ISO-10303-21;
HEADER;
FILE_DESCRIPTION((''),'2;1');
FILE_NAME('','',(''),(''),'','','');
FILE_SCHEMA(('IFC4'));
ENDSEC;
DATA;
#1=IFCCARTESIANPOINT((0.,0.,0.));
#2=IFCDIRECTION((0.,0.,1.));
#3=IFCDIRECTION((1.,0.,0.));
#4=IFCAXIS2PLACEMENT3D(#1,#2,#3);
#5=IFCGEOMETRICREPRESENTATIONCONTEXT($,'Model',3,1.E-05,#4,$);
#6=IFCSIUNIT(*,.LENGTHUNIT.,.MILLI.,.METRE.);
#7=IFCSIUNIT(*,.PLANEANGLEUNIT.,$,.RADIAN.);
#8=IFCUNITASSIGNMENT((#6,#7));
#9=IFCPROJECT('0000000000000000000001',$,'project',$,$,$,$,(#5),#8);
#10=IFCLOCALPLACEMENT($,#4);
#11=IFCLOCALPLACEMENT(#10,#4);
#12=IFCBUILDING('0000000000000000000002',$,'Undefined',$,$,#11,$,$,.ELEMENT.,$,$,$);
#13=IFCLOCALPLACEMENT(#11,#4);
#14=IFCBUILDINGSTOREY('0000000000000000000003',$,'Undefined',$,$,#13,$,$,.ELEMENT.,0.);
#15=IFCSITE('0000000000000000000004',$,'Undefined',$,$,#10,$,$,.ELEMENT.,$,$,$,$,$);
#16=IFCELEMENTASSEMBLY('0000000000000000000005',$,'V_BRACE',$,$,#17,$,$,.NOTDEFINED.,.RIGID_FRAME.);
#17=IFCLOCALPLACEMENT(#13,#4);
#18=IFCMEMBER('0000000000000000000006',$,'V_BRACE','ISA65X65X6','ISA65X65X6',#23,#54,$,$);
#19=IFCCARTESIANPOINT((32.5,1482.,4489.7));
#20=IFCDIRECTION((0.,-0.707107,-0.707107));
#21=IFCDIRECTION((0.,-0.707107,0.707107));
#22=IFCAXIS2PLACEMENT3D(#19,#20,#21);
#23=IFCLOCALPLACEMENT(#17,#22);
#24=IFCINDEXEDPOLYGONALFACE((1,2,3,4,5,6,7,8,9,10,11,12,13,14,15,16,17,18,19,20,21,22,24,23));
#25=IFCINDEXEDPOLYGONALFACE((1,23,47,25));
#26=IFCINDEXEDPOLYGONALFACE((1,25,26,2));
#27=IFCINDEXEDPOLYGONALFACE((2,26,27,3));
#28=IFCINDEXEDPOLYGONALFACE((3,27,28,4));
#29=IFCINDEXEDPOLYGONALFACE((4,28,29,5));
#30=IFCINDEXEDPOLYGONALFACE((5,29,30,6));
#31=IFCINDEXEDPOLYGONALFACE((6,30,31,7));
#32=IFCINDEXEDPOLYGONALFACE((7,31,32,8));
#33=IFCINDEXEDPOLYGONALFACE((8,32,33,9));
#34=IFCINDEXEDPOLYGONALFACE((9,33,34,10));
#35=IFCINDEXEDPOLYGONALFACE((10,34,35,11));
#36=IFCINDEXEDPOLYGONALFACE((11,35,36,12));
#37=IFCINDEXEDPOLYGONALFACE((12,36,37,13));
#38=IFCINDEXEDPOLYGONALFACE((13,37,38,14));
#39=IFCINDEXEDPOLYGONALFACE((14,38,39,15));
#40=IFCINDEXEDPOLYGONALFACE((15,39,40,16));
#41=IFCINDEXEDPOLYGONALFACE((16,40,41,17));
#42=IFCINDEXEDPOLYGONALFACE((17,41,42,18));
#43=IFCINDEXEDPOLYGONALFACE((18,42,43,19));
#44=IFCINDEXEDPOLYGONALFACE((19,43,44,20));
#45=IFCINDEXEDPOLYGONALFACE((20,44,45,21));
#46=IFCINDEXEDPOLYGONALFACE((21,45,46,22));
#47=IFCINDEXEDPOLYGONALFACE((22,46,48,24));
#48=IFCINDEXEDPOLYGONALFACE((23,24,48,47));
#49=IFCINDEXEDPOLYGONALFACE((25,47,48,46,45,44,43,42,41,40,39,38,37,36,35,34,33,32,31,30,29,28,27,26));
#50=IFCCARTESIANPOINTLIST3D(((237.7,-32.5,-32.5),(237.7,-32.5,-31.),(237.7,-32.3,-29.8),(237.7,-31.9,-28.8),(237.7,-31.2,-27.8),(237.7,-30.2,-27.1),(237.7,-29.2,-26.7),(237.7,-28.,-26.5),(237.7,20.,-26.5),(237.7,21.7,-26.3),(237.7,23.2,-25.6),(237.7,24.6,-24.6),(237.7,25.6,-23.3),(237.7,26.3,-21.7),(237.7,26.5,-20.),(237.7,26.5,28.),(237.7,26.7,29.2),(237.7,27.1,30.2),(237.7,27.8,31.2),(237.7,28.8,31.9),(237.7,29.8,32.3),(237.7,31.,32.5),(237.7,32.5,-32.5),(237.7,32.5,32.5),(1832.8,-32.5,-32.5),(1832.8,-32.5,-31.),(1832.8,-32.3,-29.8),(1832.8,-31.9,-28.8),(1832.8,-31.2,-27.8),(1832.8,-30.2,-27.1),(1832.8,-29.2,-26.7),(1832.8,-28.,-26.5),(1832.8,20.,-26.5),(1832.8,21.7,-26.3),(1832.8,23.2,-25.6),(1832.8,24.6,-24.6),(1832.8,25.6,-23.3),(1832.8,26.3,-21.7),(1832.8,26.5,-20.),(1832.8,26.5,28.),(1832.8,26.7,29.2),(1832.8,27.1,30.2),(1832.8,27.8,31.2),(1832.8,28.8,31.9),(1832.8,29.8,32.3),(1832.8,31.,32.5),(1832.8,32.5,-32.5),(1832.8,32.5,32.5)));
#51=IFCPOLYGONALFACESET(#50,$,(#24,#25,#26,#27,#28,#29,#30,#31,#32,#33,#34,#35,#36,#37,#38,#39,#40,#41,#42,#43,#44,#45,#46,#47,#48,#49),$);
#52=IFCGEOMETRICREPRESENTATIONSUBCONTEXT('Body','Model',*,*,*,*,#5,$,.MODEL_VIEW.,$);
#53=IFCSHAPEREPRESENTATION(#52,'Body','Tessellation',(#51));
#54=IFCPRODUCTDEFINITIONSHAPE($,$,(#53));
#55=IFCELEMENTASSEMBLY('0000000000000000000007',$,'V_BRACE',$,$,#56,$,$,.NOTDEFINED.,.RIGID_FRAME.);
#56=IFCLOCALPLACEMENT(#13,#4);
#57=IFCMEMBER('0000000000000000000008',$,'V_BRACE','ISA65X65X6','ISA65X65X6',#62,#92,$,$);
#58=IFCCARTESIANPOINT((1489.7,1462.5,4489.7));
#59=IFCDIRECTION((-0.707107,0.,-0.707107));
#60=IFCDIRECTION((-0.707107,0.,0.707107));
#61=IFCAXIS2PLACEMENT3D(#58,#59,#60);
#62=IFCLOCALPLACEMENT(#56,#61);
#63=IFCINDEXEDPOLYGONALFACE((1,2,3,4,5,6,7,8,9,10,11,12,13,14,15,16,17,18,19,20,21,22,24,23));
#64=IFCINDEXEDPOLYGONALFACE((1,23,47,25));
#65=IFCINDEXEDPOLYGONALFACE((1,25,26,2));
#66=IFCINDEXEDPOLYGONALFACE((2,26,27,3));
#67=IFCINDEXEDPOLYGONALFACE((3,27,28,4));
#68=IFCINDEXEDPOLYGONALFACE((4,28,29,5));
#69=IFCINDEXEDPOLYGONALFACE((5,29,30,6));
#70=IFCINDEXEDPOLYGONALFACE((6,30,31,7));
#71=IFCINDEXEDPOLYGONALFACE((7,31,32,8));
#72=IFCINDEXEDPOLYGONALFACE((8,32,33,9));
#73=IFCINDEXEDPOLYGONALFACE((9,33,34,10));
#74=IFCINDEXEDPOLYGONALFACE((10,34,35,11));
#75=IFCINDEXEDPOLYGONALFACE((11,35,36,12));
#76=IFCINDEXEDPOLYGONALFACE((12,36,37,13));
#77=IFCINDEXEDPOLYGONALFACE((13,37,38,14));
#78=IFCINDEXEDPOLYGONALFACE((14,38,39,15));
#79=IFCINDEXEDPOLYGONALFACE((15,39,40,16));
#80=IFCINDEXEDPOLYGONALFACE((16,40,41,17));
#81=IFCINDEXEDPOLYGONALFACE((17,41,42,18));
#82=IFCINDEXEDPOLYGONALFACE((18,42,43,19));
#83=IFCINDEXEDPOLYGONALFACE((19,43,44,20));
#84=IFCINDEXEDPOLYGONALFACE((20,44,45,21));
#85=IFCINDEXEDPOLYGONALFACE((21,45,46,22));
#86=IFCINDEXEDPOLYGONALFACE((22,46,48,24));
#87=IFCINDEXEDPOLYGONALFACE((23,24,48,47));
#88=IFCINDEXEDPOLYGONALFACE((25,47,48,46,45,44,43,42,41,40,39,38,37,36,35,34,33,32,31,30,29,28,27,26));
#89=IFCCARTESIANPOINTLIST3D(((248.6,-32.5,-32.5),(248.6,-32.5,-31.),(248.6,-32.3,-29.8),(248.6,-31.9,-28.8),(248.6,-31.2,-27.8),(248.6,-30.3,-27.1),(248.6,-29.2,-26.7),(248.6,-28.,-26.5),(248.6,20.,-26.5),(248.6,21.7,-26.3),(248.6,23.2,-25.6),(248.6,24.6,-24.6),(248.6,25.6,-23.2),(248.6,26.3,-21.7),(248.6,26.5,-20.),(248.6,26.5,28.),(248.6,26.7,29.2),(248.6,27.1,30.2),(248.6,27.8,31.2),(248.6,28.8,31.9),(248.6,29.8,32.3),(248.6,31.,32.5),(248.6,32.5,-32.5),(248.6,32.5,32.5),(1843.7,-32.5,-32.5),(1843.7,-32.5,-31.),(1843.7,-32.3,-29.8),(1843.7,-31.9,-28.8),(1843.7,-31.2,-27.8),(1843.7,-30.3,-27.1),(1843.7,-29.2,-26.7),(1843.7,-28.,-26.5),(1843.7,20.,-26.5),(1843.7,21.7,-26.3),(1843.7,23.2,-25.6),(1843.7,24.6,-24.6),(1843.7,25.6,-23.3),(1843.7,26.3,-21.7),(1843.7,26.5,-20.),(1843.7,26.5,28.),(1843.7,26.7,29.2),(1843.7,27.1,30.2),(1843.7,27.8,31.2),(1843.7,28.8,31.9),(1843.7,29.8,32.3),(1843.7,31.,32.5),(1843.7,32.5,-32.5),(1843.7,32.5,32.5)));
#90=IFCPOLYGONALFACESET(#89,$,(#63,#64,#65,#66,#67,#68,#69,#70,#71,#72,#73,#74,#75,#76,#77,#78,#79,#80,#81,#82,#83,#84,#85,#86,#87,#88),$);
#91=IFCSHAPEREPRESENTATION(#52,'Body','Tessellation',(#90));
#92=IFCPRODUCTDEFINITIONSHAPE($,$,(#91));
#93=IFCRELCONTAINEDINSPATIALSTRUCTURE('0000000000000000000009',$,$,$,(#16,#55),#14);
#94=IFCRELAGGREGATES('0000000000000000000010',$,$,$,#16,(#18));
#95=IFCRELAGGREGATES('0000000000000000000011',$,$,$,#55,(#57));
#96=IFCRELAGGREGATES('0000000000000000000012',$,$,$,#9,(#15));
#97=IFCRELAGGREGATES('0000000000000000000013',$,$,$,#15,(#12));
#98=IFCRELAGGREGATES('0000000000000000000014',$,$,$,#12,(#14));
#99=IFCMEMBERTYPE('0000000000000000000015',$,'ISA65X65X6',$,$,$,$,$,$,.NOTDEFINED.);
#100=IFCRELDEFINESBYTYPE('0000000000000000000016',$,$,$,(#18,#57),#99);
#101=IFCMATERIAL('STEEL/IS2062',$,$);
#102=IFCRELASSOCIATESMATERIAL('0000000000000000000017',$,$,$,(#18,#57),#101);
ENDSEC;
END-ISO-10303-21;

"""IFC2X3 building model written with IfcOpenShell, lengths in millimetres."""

from ifc_helpers import new_model, si_unit, frame, origin_with_axes, origin_2d_with_axis, place, context, subcontext, project, spatial, l_section, extrude, clip, halfspace, material, type_object, element, aggregate, save


model = new_model("IFC2X3")

# Units and contexts
model_context = context("Model", 3, precision=1e-05, world=origin_with_axes())
body_context = subcontext(model_context, "Body", "Model", "MODEL_VIEW")
ifc_project = project(units=[si_unit("LENGTHUNIT", "METRE", prefix="MILLI"), si_unit("PLANEANGLEUNIT", "RADIAN")], contexts=[model_context])

# Site, building, storey
site_placement = place(None, origin_with_axes())
site = spatial("IfcSite", under=ifc_project, at=site_placement, Name="Undefined", CompositionType="ELEMENT")
building_placement = place(site_placement, origin_with_axes())
building = spatial("IfcBuilding", under=site, at=building_placement, Name="Undefined", CompositionType="ELEMENT")
storey_placement = place(building_placement, origin_with_axes())
storey = spatial("IfcBuildingStorey", under=building, at=storey_placement, Name="Undefined", CompositionType="ELEMENT", Elevation=0.0)

# Shared definitions
ifc_material = material(Name="STEEL/IS2062")

# Element assemblies, members
assembly_1_placement = place(storey_placement, origin_with_axes())
assembly_1 = element("IfcElementAssembly", 1, at=assembly_1_placement, inside=storey, Name="V_BRACE", AssemblyPlace="NOTDEFINED", PredefinedType="RIGID_FRAME")
member_type = type_object("IfcMemberType", Name="ISA65X65X6", PredefinedType="NOTDEFINED")
member_1_placement = place(assembly_1_placement, frame((32.5, 1482.0, 4489.7), z_axis=(0.0, -0.707107, -0.707107), x_axis=(0.0, -0.707107, 0.707107)))
member_1 = element("IfcMember", 2, at=member_1_placement, type_object=member_type, material=ifc_material, Name="V_BRACE", Description="ISA65X65X6", ObjectType="ISA65X65X6", context=body_context, shape_type="Clipping", body=[
    clip(clip(extrude(l_section(Depth=65.0, Width=65.0, Thickness=6.0, FilletRadius=6.5, EdgeRadius=4.5, at=origin_2d_with_axis()), frame((2121.3, 0.0, 0.0), z_axis=(-1.0, 0.0, 0.0), x_axis=(0.0, -1.0, 0.0)), (0.0, 0.0, 1.0), 2121.3), halfspace(frame((1832.8, 42.5, 0.0), z_axis=(-1.0, 0.0, 0.0), x_axis=(0.0, 0.0, 1.0)), True)), halfspace(frame((237.7, 42.5, 0.0), z_axis=(1.0, 0.0, 0.0), x_axis=(0.0, 0.0, -1.0)), True)),
])
aggregate(assembly_1, [member_1])
assembly_2_placement = place(storey_placement, origin_with_axes())
assembly_2 = element("IfcElementAssembly", 3, at=assembly_2_placement, inside=storey, Name="V_BRACE", AssemblyPlace="NOTDEFINED", PredefinedType="RIGID_FRAME")
member_2_placement = place(assembly_2_placement, frame((1489.7, 1462.5, 4489.7), z_axis=(-0.707107, 0.0, -0.707107), x_axis=(-0.707107, 0.0, 0.707107)))
member_2 = element("IfcMember", 4, at=member_2_placement, type_object=member_type, material=ifc_material, Name="V_BRACE", Description="ISA65X65X6", ObjectType="ISA65X65X6", context=body_context, shape_type="Clipping", body=[
    clip(clip(extrude(l_section(Depth=65.0, Width=65.0, Thickness=6.0, FilletRadius=6.5, EdgeRadius=4.5, at=origin_2d_with_axis()), frame((2121.3, 0.0, 0.0), z_axis=(-1.0, 0.0, 0.0), x_axis=(0.0, -1.0, 0.0)), (0.0, 0.0, 1.0), 2121.3), halfspace(frame((1843.7, 32.5, 0.0), z_axis=(-1.0, 0.0, 0.0), x_axis=(0.0, 0.0, -1.0)), True)), halfspace(frame((248.6, 32.5, 0.0), z_axis=(1.0, 0.0, 0.0), x_axis=(0.0, 0.0, 1.0)), True)),
])
aggregate(assembly_2, [member_2])

save(model, "model.ifc")
